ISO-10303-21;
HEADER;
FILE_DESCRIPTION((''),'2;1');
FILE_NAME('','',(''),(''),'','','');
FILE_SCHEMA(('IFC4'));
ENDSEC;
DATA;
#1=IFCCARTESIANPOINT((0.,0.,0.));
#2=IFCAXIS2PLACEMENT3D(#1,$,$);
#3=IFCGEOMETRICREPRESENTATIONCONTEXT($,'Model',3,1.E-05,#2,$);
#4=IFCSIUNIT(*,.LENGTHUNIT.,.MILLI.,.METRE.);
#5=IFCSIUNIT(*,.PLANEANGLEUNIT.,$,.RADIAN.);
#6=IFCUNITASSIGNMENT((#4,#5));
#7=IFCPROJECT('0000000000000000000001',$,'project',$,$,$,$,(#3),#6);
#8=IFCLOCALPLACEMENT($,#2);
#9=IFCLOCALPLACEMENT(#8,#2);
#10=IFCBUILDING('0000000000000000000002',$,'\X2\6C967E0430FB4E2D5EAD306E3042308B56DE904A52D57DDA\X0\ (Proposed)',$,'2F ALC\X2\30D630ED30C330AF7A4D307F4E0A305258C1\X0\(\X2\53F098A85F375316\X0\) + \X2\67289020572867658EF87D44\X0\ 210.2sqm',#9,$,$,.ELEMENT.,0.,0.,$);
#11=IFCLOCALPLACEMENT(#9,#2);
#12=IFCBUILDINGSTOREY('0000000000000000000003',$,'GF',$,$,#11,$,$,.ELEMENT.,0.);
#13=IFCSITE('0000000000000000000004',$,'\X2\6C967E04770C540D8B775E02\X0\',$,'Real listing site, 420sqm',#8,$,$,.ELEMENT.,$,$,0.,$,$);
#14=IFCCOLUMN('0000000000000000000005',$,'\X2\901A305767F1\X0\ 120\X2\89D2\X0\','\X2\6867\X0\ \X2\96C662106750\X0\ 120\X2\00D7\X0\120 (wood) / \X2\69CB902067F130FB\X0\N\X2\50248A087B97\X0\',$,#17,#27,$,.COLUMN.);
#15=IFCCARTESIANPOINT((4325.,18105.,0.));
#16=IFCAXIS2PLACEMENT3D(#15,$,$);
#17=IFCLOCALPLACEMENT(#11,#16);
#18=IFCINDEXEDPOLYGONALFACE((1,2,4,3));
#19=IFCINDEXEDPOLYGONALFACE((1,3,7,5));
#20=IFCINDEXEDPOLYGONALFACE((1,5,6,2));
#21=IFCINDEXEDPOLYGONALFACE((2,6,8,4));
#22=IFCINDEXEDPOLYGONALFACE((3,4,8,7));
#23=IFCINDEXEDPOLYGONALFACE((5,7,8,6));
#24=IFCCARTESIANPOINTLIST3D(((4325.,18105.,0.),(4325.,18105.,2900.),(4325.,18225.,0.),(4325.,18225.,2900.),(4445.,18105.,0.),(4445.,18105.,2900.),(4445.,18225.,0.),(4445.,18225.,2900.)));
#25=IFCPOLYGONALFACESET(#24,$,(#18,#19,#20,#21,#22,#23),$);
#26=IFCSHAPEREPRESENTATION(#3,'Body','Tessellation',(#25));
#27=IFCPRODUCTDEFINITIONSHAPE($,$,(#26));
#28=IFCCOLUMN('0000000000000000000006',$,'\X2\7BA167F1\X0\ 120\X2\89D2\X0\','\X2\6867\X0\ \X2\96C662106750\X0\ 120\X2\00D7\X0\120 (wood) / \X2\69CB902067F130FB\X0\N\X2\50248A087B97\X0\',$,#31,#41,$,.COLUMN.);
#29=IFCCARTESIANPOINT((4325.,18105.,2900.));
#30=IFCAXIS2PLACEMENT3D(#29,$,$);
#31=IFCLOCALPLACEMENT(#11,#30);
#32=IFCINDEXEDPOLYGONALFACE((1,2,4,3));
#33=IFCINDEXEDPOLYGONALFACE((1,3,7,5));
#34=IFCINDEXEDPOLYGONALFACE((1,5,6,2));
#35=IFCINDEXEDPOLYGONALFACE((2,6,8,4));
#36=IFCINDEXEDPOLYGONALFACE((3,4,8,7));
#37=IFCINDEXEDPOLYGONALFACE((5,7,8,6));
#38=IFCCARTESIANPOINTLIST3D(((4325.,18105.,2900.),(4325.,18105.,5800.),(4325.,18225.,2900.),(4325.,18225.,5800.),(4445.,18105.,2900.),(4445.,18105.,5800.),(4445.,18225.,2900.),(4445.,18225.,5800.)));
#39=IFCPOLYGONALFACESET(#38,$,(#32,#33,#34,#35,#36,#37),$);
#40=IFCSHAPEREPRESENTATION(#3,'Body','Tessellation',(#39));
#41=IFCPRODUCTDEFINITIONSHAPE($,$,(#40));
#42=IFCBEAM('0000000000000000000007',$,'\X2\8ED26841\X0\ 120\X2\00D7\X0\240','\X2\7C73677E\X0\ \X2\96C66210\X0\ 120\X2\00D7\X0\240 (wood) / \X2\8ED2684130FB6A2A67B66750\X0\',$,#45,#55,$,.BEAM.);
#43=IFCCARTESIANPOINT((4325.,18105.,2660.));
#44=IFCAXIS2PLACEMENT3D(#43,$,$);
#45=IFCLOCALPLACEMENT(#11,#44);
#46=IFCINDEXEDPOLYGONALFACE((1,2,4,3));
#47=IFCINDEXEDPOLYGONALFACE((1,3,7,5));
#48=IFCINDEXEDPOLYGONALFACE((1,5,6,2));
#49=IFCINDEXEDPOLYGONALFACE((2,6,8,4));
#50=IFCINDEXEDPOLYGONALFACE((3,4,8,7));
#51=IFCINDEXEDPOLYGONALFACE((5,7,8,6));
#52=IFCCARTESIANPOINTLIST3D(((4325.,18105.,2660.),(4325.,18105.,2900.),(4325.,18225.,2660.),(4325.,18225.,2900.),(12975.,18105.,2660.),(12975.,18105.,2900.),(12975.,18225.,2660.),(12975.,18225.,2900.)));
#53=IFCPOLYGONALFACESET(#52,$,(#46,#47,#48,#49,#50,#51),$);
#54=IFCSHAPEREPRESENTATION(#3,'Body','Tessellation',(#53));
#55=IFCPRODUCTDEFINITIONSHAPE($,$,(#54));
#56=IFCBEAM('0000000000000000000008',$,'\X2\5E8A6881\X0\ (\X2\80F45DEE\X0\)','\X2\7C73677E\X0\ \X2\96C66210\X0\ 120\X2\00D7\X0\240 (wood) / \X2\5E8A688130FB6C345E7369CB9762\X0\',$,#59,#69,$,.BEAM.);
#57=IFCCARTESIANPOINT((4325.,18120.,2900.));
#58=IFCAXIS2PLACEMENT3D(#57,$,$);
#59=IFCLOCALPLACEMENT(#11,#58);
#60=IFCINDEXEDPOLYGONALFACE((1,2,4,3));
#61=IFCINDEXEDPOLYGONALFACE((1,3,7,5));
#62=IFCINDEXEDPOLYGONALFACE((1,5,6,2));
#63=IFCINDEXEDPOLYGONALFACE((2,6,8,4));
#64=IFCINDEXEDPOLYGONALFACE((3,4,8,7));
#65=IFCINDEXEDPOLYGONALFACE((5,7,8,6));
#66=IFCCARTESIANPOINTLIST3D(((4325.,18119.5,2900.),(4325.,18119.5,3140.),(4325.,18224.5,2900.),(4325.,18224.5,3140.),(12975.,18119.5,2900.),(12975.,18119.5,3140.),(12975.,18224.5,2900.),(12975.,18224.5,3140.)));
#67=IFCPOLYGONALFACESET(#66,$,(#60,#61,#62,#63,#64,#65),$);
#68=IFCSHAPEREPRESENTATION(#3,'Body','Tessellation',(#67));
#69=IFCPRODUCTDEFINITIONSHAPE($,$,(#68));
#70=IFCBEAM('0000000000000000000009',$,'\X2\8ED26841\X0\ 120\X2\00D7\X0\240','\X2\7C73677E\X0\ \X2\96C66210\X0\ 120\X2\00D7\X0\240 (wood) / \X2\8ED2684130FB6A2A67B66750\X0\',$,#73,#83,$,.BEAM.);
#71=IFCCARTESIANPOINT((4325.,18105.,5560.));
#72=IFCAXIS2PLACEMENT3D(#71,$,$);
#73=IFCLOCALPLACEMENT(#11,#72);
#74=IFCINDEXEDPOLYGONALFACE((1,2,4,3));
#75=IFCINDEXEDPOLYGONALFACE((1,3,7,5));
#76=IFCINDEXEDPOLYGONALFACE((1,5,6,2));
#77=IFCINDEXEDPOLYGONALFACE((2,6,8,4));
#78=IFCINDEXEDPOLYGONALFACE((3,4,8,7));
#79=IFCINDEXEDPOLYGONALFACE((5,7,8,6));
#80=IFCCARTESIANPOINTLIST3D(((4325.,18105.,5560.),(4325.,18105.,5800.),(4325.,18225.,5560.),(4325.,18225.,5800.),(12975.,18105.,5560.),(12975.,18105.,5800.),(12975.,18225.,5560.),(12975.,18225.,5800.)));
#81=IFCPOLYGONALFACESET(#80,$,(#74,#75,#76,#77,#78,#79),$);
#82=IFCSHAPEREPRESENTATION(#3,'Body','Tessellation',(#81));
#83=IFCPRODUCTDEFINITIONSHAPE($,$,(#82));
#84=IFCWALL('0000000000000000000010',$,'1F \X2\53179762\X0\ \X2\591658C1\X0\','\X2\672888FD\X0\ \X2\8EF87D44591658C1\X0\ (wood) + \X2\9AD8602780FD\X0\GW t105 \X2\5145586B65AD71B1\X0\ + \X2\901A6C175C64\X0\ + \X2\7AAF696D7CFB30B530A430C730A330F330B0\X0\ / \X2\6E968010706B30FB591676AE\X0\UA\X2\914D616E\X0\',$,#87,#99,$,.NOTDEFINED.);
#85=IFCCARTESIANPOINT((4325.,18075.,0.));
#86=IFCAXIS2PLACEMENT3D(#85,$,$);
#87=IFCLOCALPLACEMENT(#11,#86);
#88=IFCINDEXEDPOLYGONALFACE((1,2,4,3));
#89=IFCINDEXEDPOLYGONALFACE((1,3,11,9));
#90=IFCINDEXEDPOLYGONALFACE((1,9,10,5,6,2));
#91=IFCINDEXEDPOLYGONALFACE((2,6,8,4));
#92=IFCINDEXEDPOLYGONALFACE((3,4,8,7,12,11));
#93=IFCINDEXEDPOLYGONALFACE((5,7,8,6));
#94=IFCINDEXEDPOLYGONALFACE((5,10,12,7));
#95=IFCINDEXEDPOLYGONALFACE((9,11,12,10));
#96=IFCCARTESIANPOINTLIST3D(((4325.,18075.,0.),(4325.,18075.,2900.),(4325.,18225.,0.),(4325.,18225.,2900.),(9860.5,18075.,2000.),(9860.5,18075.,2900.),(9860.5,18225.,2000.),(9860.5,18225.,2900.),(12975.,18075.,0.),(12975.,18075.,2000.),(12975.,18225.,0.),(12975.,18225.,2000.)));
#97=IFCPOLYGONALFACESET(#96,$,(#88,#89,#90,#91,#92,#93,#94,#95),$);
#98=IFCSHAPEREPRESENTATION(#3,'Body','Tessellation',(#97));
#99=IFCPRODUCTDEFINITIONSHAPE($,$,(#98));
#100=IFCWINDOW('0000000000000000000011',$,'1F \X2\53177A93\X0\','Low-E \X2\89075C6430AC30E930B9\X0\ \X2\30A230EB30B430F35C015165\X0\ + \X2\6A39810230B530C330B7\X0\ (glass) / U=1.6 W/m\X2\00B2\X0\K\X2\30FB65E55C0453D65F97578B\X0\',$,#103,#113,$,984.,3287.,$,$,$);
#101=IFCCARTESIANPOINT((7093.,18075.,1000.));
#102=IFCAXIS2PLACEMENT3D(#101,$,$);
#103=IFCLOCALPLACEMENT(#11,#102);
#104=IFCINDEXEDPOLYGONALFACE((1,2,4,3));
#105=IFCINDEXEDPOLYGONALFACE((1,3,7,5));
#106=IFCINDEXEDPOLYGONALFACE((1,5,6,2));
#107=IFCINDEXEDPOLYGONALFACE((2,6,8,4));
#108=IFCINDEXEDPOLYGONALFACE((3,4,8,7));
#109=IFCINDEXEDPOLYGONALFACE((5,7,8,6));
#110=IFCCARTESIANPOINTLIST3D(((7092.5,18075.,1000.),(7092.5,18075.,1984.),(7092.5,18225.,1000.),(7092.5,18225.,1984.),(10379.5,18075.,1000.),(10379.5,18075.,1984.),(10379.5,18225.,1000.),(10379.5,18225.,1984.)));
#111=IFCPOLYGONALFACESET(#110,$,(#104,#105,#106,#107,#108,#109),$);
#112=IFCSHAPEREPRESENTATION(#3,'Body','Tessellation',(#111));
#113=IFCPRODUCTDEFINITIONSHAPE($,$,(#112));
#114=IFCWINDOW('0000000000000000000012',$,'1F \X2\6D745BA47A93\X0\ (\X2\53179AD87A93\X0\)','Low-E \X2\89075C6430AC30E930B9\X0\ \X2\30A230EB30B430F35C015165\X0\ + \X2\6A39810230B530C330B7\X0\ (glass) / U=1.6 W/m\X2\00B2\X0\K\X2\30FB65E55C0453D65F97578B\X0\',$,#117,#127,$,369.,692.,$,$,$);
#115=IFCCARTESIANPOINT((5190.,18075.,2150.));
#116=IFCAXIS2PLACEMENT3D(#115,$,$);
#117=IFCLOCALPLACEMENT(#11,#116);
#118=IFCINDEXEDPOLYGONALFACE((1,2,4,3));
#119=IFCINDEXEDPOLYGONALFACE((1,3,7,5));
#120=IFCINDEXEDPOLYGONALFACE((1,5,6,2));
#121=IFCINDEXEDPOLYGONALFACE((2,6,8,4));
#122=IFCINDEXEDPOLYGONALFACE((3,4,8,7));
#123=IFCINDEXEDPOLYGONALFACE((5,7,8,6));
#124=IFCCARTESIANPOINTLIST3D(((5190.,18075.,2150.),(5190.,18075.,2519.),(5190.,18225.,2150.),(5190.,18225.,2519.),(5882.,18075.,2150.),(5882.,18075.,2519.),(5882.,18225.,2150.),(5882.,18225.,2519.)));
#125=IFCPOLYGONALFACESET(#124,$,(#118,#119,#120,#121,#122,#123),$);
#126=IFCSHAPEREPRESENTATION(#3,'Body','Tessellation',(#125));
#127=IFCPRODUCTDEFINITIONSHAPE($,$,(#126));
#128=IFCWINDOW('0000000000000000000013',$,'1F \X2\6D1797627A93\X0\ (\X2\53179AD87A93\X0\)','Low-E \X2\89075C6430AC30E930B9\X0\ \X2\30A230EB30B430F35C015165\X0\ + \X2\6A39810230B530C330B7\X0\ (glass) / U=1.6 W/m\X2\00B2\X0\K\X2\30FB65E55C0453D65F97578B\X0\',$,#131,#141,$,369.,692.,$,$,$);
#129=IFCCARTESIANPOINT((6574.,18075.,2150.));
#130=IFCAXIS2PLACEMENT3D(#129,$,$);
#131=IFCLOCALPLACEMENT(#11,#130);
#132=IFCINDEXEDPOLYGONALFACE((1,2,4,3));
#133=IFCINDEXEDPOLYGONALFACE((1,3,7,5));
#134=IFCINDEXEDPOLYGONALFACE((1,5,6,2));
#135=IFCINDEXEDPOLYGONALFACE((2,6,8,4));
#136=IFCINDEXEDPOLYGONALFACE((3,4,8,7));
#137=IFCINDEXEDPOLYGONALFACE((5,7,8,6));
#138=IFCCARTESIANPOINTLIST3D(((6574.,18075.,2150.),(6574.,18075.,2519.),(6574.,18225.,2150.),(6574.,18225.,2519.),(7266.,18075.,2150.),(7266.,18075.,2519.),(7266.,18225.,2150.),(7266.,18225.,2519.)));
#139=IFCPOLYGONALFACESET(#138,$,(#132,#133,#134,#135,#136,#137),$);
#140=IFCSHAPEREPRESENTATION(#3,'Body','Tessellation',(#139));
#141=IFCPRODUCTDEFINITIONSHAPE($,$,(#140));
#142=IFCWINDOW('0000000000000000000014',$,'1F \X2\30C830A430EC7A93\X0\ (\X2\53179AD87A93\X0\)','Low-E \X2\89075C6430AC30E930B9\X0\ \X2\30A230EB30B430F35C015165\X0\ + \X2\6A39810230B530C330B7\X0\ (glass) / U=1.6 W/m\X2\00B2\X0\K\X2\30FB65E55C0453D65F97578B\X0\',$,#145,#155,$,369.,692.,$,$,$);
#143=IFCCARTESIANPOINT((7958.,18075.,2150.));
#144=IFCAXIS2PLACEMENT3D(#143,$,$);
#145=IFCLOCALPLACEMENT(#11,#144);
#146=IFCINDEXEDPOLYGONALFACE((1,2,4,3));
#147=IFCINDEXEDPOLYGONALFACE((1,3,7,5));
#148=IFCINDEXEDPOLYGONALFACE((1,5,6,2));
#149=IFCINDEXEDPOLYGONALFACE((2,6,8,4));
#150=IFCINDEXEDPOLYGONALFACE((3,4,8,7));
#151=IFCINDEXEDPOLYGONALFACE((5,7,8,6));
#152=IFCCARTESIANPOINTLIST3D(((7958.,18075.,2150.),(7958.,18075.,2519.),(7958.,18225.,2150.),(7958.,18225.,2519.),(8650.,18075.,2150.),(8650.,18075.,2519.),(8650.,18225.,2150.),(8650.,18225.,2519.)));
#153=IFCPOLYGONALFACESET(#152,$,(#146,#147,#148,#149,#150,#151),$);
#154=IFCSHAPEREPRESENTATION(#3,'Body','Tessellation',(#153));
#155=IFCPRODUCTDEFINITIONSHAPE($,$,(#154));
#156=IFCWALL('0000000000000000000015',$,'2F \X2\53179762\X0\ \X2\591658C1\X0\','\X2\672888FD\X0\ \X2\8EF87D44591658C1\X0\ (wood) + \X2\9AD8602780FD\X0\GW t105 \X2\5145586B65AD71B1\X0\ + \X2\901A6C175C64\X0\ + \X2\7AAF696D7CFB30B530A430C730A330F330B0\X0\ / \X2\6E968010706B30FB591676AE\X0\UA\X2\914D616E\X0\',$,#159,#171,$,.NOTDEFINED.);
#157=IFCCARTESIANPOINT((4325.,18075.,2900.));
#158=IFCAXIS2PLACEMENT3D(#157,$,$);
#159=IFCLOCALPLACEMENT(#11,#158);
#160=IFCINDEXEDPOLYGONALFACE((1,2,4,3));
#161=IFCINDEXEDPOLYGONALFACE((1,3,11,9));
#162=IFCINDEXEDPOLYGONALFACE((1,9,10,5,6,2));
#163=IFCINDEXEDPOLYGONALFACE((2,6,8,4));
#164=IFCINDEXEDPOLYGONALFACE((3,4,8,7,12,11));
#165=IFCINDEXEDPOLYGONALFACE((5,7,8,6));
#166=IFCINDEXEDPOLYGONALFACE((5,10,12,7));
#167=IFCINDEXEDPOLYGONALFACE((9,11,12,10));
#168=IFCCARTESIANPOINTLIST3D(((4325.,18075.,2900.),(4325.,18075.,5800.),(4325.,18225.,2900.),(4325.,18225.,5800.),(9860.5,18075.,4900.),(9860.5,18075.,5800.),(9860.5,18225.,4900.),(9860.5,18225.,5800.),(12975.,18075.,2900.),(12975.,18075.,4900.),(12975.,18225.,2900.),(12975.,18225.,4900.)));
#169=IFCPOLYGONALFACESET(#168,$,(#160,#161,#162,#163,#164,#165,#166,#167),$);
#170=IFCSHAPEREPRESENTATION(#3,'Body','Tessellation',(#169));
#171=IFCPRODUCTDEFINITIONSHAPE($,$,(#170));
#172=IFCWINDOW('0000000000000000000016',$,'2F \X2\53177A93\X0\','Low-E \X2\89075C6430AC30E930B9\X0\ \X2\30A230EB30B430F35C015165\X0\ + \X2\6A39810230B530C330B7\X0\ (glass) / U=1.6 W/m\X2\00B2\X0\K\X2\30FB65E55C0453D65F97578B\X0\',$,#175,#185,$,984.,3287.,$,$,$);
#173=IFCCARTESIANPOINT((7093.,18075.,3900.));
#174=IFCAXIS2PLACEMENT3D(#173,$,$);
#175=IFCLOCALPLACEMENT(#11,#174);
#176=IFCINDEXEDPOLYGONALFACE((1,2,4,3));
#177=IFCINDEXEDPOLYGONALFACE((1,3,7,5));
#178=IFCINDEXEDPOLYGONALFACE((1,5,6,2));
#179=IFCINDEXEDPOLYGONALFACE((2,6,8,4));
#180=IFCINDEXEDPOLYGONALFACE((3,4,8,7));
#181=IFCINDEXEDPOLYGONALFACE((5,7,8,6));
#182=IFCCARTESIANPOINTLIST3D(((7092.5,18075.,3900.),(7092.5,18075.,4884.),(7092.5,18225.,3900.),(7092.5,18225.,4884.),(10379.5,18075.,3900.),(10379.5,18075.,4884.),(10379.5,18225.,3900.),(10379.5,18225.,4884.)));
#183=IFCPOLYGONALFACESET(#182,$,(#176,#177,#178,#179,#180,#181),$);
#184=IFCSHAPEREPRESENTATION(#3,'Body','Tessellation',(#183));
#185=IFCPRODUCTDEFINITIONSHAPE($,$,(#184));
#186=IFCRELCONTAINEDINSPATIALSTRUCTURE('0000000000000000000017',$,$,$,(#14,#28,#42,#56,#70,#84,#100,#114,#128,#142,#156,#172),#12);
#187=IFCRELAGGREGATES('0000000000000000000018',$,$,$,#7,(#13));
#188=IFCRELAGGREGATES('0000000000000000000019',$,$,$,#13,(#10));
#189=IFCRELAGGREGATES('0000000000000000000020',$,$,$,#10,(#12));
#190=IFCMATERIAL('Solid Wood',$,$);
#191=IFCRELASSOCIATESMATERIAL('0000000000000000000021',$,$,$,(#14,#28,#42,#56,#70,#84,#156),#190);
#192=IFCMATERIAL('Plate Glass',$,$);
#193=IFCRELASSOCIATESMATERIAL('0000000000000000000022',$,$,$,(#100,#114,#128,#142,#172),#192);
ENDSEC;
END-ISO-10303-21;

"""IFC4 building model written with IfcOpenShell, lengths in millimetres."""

from ifc_helpers import new_model, si_unit, frame, frame_2d, origin, place, context, project, spatial, rectangle, extrude, material, element, fill, save


model = new_model("IFC4")

# Units and contexts
model_context = context("Model", 3, precision=1e-05, world=origin())
ifc_project = project(units=[si_unit("LENGTHUNIT", "METRE", prefix="MILLI"), si_unit("PLANEANGLEUNIT", "RADIAN")], contexts=[model_context])

# Site, building, storey
site_placement = place(None, origin())
site = spatial("IfcSite", under=ifc_project, at=site_placement, Name="沖縄県名護市", ObjectType="Real listing site, 420sqm", CompositionType="ELEMENT", RefElevation=0.0)
building_placement = place(site_placement, origin())
building = spatial("IfcBuilding", under=site, at=building_placement, Name="沖縄・中庭のある回遊動線 (Proposed)", ObjectType="2F ALCブロック積み上げ壁(台風強化) + 木造在来軸組 210.2sqm", CompositionType="ELEMENT", ElevationOfRefHeight=0.0, ElevationOfTerrain=0.0)
storey_placement = place(building_placement, origin())
storey = spatial("IfcBuildingStorey", under=building, at=storey_placement, Name="GF", CompositionType="ELEMENT", Elevation=0.0)

# Columns
ifc_material_1 = material(Name="Solid Wood")
column_1_placement = place(storey_placement, frame((4325.0, 18105.0, 0.0)))
element("IfcColumn", 1, at=column_1_placement, inside=storey, material=ifc_material_1, Name="通し柱 120角", Description="桧 集成材 120×120 (wood) / 構造柱・N値計算", PredefinedType="COLUMN", context=model_context, shape_type="SweptSolid", body=[
    extrude(rectangle(XDim=120.0, YDim=120.0, at=frame_2d((60.0, 60.0))), frame((4325.0, 18105.0, 0.0)), (0.0, 0.0, 1.0), 2900.0),
])
column_2_placement = place(storey_placement, frame((4325.0, 18105.0, 2900.0)))
element("IfcColumn", 2, at=column_2_placement, inside=storey, material=ifc_material_1, Name="管柱 120角", Description="桧 集成材 120×120 (wood) / 構造柱・N値計算", PredefinedType="COLUMN", context=model_context, shape_type="SweptSolid", body=[
    extrude(rectangle(XDim=120.0, YDim=120.0, at=frame_2d((60.0, 60.0))), frame((4325.0, 18105.0, 2900.0)), (0.0, 0.0, 1.0), 2900.0),
])

# Beams
beam_1_placement = place(storey_placement, frame((4325.0, 18105.0, 2660.0)))
element("IfcBeam", 3, at=beam_1_placement, inside=storey, material=ifc_material_1, Name="軒桁 120×240", Description="米松 集成 120×240 (wood) / 軒桁・横架材", PredefinedType="BEAM", context=model_context, shape_type="SweptSolid", body=[
    extrude(rectangle(XDim=8650.0, YDim=120.0, at=frame_2d((4325.0, 60.0))), frame((4325.0, 18105.0, 2660.0)), (0.0, 0.0, 1.0), 240.0),
])
beam_2_placement = place(storey_placement, frame((4325.0, 18120.0, 2900.0)))
element("IfcBeam", 4, at=beam_2_placement, inside=storey, material=ifc_material_1, Name="床梁 (胴差)", Description="米松 集成 120×240 (wood) / 床梁・水平構面", PredefinedType="BEAM", context=model_context, shape_type="SweptSolid", body=[
    extrude(rectangle(XDim=8650.0, YDim=105.0, at=frame_2d((4325.0, 52.0))), frame((4325.0, 18120.0, 2900.0)), (0.0, 0.0, 1.0), 240.0),
])
beam_3_placement = place(storey_placement, frame((4325.0, 18105.0, 5560.0)))
element("IfcBeam", 5, at=beam_3_placement, inside=storey, material=ifc_material_1, Name="軒桁 120×240", Description="米松 集成 120×240 (wood) / 軒桁・横架材", PredefinedType="BEAM", context=model_context, shape_type="SweptSolid", body=[
    extrude(rectangle(XDim=8650.0, YDim=120.0, at=frame_2d((4325.0, 60.0))), frame((4325.0, 18105.0, 5560.0)), (0.0, 0.0, 1.0), 240.0),
])

# Wall, openings, windows
wall_1_placement = place(storey_placement, frame((4325.0, 18075.0, 0.0)))
wall_1 = element("IfcWall", 6, at=wall_1_placement, inside=storey, material=ifc_material_1, Name="1F 北面 外壁", Description="木製 軸組外壁 (wood) + 高性能GW t105 充填断熱 + 通気層 + 窯業系サイディング / 準耐火・外皮UA配慮", PredefinedType="NOTDEFINED", context=model_context, shape_type="SweptSolid", body=[
    extrude(rectangle(XDim=8650.0, YDim=150.0, at=frame_2d((4325.0, 75.0))), frame((4325.0, 18075.0, 0.0)), (0.0, 0.0, 1.0), 2900.0),
])
opening_1_placement = place(storey_placement, frame((7093.0, 18075.0, 1000.0)))
opening_1 = element("IfcOpeningElement", 7, at=opening_1_placement, cuts=wall_1, PredefinedType="NOTDEFINED", context=model_context, shape_type="SweptSolid", body=[
    extrude(rectangle(XDim=3287.0, YDim=150.0, at=frame_2d((1643.0, 75.0))), frame((7093.0, 18075.0, 1000.0)), (0.0, 0.0, 1.0), 984.0),
])
opening_2_placement = place(storey_placement, frame((5190.0, 18075.0, 2150.0)))
opening_2 = element("IfcOpeningElement", 8, at=opening_2_placement, cuts=wall_1, PredefinedType="NOTDEFINED", context=model_context, shape_type="SweptSolid", body=[
    extrude(rectangle(XDim=692.0, YDim=150.0, at=frame_2d((346.0, 75.0))), frame((5190.0, 18075.0, 2150.0)), (0.0, 0.0, 1.0), 369.0),
])
opening_3_placement = place(storey_placement, frame((6574.0, 18075.0, 2150.0)))
opening_3 = element("IfcOpeningElement", 9, at=opening_3_placement, cuts=wall_1, PredefinedType="NOTDEFINED", context=model_context, shape_type="SweptSolid", body=[
    extrude(rectangle(XDim=692.0, YDim=150.0, at=frame_2d((346.0, 75.0))), frame((6574.0, 18075.0, 2150.0)), (0.0, 0.0, 1.0), 369.0),
])
opening_4_placement = place(storey_placement, frame((7958.0, 18075.0, 2150.0)))
opening_4 = element("IfcOpeningElement", 10, at=opening_4_placement, cuts=wall_1, PredefinedType="NOTDEFINED", context=model_context, shape_type="SweptSolid", body=[
    extrude(rectangle(XDim=692.0, YDim=150.0, at=frame_2d((346.0, 75.0))), frame((7958.0, 18075.0, 2150.0)), (0.0, 0.0, 1.0), 369.0),
])
ifc_material_2 = material(Name="Plate Glass")
window_1_placement = place(storey_placement, frame((7093.0, 18075.0, 1000.0)))
window_1 = element("IfcWindow", 11, at=window_1_placement, inside=storey, material=ifc_material_2, Name="1F 北窓", Description="Low-E 複層ガラス アルゴン封入 + 樹脂サッシ (glass) / U=1.6 W/m²K・日射取得型", OverallHeight=984.0, OverallWidth=3287.0, context=model_context, shape_type="SweptSolid", body=[
    extrude(rectangle(XDim=3287.0, YDim=150.0, at=frame_2d((1643.0, 75.0))), frame((7093.0, 18075.0, 1000.0)), (0.0, 0.0, 1.0), 984.0),
])
fill(opening_1, window_1)
window_2_placement = place(storey_placement, frame((5190.0, 18075.0, 2150.0)))
window_2 = element("IfcWindow", 12, at=window_2_placement, inside=storey, material=ifc_material_2, Name="1F 浴室窓 (北高窓)", Description="Low-E 複層ガラス アルゴン封入 + 樹脂サッシ (glass) / U=1.6 W/m²K・日射取得型", OverallHeight=369.0, OverallWidth=692.0, context=model_context, shape_type="SweptSolid", body=[
    extrude(rectangle(XDim=692.0, YDim=150.0, at=frame_2d((346.0, 75.0))), frame((5190.0, 18075.0, 2150.0)), (0.0, 0.0, 1.0), 369.0),
])
fill(opening_2, window_2)
window_3_placement = place(storey_placement, frame((6574.0, 18075.0, 2150.0)))
window_3 = element("IfcWindow", 13, at=window_3_placement, inside=storey, material=ifc_material_2, Name="1F 洗面窓 (北高窓)", Description="Low-E 複層ガラス アルゴン封入 + 樹脂サッシ (glass) / U=1.6 W/m²K・日射取得型", OverallHeight=369.0, OverallWidth=692.0, context=model_context, shape_type="SweptSolid", body=[
    extrude(rectangle(XDim=692.0, YDim=150.0, at=frame_2d((346.0, 75.0))), frame((6574.0, 18075.0, 2150.0)), (0.0, 0.0, 1.0), 369.0),
])
fill(opening_3, window_3)
window_4_placement = place(storey_placement, frame((7958.0, 18075.0, 2150.0)))
window_4 = element("IfcWindow", 14, at=window_4_placement, inside=storey, material=ifc_material_2, Name="1F トイレ窓 (北高窓)", Description="Low-E 複層ガラス アルゴン封入 + 樹脂サッシ (glass) / U=1.6 W/m²K・日射取得型", OverallHeight=369.0, OverallWidth=692.0, context=model_context, shape_type="SweptSolid", body=[
    extrude(rectangle(XDim=692.0, YDim=150.0, at=frame_2d((346.0, 75.0))), frame((7958.0, 18075.0, 2150.0)), (0.0, 0.0, 1.0), 369.0),
])
fill(opening_4, window_4)

# Wall, opening, window
wall_2_placement = place(storey_placement, frame((4325.0, 18075.0, 2900.0)))
wall_2 = element("IfcWall", 15, at=wall_2_placement, inside=storey, material=ifc_material_1, Name="2F 北面 外壁", Description="木製 軸組外壁 (wood) + 高性能GW t105 充填断熱 + 通気層 + 窯業系サイディング / 準耐火・外皮UA配慮", PredefinedType="NOTDEFINED", context=model_context, shape_type="SweptSolid", body=[
    extrude(rectangle(XDim=8650.0, YDim=150.0, at=frame_2d((4325.0, 75.0))), frame((4325.0, 18075.0, 2900.0)), (0.0, 0.0, 1.0), 2900.0),
])
opening_5_placement = place(storey_placement, frame((7093.0, 18075.0, 3900.0)))
opening_5 = element("IfcOpeningElement", 16, at=opening_5_placement, cuts=wall_2, PredefinedType="NOTDEFINED", context=model_context, shape_type="SweptSolid", body=[
    extrude(rectangle(XDim=3287.0, YDim=150.0, at=frame_2d((1643.0, 75.0))), frame((7093.0, 18075.0, 3900.0)), (0.0, 0.0, 1.0), 984.0),
])
window_5_placement = place(storey_placement, frame((7093.0, 18075.0, 3900.0)))
window_5 = element("IfcWindow", 17, at=window_5_placement, inside=storey, material=ifc_material_2, Name="2F 北窓", Description="Low-E 複層ガラス アルゴン封入 + 樹脂サッシ (glass) / U=1.6 W/m²K・日射取得型", OverallHeight=984.0, OverallWidth=3287.0, context=model_context, shape_type="SweptSolid", body=[
    extrude(rectangle(XDim=3287.0, YDim=150.0, at=frame_2d((1643.0, 75.0))), frame((7093.0, 18075.0, 3900.0)), (0.0, 0.0, 1.0), 984.0),
])
fill(opening_5, window_5)

save(model, "model.ifc")
